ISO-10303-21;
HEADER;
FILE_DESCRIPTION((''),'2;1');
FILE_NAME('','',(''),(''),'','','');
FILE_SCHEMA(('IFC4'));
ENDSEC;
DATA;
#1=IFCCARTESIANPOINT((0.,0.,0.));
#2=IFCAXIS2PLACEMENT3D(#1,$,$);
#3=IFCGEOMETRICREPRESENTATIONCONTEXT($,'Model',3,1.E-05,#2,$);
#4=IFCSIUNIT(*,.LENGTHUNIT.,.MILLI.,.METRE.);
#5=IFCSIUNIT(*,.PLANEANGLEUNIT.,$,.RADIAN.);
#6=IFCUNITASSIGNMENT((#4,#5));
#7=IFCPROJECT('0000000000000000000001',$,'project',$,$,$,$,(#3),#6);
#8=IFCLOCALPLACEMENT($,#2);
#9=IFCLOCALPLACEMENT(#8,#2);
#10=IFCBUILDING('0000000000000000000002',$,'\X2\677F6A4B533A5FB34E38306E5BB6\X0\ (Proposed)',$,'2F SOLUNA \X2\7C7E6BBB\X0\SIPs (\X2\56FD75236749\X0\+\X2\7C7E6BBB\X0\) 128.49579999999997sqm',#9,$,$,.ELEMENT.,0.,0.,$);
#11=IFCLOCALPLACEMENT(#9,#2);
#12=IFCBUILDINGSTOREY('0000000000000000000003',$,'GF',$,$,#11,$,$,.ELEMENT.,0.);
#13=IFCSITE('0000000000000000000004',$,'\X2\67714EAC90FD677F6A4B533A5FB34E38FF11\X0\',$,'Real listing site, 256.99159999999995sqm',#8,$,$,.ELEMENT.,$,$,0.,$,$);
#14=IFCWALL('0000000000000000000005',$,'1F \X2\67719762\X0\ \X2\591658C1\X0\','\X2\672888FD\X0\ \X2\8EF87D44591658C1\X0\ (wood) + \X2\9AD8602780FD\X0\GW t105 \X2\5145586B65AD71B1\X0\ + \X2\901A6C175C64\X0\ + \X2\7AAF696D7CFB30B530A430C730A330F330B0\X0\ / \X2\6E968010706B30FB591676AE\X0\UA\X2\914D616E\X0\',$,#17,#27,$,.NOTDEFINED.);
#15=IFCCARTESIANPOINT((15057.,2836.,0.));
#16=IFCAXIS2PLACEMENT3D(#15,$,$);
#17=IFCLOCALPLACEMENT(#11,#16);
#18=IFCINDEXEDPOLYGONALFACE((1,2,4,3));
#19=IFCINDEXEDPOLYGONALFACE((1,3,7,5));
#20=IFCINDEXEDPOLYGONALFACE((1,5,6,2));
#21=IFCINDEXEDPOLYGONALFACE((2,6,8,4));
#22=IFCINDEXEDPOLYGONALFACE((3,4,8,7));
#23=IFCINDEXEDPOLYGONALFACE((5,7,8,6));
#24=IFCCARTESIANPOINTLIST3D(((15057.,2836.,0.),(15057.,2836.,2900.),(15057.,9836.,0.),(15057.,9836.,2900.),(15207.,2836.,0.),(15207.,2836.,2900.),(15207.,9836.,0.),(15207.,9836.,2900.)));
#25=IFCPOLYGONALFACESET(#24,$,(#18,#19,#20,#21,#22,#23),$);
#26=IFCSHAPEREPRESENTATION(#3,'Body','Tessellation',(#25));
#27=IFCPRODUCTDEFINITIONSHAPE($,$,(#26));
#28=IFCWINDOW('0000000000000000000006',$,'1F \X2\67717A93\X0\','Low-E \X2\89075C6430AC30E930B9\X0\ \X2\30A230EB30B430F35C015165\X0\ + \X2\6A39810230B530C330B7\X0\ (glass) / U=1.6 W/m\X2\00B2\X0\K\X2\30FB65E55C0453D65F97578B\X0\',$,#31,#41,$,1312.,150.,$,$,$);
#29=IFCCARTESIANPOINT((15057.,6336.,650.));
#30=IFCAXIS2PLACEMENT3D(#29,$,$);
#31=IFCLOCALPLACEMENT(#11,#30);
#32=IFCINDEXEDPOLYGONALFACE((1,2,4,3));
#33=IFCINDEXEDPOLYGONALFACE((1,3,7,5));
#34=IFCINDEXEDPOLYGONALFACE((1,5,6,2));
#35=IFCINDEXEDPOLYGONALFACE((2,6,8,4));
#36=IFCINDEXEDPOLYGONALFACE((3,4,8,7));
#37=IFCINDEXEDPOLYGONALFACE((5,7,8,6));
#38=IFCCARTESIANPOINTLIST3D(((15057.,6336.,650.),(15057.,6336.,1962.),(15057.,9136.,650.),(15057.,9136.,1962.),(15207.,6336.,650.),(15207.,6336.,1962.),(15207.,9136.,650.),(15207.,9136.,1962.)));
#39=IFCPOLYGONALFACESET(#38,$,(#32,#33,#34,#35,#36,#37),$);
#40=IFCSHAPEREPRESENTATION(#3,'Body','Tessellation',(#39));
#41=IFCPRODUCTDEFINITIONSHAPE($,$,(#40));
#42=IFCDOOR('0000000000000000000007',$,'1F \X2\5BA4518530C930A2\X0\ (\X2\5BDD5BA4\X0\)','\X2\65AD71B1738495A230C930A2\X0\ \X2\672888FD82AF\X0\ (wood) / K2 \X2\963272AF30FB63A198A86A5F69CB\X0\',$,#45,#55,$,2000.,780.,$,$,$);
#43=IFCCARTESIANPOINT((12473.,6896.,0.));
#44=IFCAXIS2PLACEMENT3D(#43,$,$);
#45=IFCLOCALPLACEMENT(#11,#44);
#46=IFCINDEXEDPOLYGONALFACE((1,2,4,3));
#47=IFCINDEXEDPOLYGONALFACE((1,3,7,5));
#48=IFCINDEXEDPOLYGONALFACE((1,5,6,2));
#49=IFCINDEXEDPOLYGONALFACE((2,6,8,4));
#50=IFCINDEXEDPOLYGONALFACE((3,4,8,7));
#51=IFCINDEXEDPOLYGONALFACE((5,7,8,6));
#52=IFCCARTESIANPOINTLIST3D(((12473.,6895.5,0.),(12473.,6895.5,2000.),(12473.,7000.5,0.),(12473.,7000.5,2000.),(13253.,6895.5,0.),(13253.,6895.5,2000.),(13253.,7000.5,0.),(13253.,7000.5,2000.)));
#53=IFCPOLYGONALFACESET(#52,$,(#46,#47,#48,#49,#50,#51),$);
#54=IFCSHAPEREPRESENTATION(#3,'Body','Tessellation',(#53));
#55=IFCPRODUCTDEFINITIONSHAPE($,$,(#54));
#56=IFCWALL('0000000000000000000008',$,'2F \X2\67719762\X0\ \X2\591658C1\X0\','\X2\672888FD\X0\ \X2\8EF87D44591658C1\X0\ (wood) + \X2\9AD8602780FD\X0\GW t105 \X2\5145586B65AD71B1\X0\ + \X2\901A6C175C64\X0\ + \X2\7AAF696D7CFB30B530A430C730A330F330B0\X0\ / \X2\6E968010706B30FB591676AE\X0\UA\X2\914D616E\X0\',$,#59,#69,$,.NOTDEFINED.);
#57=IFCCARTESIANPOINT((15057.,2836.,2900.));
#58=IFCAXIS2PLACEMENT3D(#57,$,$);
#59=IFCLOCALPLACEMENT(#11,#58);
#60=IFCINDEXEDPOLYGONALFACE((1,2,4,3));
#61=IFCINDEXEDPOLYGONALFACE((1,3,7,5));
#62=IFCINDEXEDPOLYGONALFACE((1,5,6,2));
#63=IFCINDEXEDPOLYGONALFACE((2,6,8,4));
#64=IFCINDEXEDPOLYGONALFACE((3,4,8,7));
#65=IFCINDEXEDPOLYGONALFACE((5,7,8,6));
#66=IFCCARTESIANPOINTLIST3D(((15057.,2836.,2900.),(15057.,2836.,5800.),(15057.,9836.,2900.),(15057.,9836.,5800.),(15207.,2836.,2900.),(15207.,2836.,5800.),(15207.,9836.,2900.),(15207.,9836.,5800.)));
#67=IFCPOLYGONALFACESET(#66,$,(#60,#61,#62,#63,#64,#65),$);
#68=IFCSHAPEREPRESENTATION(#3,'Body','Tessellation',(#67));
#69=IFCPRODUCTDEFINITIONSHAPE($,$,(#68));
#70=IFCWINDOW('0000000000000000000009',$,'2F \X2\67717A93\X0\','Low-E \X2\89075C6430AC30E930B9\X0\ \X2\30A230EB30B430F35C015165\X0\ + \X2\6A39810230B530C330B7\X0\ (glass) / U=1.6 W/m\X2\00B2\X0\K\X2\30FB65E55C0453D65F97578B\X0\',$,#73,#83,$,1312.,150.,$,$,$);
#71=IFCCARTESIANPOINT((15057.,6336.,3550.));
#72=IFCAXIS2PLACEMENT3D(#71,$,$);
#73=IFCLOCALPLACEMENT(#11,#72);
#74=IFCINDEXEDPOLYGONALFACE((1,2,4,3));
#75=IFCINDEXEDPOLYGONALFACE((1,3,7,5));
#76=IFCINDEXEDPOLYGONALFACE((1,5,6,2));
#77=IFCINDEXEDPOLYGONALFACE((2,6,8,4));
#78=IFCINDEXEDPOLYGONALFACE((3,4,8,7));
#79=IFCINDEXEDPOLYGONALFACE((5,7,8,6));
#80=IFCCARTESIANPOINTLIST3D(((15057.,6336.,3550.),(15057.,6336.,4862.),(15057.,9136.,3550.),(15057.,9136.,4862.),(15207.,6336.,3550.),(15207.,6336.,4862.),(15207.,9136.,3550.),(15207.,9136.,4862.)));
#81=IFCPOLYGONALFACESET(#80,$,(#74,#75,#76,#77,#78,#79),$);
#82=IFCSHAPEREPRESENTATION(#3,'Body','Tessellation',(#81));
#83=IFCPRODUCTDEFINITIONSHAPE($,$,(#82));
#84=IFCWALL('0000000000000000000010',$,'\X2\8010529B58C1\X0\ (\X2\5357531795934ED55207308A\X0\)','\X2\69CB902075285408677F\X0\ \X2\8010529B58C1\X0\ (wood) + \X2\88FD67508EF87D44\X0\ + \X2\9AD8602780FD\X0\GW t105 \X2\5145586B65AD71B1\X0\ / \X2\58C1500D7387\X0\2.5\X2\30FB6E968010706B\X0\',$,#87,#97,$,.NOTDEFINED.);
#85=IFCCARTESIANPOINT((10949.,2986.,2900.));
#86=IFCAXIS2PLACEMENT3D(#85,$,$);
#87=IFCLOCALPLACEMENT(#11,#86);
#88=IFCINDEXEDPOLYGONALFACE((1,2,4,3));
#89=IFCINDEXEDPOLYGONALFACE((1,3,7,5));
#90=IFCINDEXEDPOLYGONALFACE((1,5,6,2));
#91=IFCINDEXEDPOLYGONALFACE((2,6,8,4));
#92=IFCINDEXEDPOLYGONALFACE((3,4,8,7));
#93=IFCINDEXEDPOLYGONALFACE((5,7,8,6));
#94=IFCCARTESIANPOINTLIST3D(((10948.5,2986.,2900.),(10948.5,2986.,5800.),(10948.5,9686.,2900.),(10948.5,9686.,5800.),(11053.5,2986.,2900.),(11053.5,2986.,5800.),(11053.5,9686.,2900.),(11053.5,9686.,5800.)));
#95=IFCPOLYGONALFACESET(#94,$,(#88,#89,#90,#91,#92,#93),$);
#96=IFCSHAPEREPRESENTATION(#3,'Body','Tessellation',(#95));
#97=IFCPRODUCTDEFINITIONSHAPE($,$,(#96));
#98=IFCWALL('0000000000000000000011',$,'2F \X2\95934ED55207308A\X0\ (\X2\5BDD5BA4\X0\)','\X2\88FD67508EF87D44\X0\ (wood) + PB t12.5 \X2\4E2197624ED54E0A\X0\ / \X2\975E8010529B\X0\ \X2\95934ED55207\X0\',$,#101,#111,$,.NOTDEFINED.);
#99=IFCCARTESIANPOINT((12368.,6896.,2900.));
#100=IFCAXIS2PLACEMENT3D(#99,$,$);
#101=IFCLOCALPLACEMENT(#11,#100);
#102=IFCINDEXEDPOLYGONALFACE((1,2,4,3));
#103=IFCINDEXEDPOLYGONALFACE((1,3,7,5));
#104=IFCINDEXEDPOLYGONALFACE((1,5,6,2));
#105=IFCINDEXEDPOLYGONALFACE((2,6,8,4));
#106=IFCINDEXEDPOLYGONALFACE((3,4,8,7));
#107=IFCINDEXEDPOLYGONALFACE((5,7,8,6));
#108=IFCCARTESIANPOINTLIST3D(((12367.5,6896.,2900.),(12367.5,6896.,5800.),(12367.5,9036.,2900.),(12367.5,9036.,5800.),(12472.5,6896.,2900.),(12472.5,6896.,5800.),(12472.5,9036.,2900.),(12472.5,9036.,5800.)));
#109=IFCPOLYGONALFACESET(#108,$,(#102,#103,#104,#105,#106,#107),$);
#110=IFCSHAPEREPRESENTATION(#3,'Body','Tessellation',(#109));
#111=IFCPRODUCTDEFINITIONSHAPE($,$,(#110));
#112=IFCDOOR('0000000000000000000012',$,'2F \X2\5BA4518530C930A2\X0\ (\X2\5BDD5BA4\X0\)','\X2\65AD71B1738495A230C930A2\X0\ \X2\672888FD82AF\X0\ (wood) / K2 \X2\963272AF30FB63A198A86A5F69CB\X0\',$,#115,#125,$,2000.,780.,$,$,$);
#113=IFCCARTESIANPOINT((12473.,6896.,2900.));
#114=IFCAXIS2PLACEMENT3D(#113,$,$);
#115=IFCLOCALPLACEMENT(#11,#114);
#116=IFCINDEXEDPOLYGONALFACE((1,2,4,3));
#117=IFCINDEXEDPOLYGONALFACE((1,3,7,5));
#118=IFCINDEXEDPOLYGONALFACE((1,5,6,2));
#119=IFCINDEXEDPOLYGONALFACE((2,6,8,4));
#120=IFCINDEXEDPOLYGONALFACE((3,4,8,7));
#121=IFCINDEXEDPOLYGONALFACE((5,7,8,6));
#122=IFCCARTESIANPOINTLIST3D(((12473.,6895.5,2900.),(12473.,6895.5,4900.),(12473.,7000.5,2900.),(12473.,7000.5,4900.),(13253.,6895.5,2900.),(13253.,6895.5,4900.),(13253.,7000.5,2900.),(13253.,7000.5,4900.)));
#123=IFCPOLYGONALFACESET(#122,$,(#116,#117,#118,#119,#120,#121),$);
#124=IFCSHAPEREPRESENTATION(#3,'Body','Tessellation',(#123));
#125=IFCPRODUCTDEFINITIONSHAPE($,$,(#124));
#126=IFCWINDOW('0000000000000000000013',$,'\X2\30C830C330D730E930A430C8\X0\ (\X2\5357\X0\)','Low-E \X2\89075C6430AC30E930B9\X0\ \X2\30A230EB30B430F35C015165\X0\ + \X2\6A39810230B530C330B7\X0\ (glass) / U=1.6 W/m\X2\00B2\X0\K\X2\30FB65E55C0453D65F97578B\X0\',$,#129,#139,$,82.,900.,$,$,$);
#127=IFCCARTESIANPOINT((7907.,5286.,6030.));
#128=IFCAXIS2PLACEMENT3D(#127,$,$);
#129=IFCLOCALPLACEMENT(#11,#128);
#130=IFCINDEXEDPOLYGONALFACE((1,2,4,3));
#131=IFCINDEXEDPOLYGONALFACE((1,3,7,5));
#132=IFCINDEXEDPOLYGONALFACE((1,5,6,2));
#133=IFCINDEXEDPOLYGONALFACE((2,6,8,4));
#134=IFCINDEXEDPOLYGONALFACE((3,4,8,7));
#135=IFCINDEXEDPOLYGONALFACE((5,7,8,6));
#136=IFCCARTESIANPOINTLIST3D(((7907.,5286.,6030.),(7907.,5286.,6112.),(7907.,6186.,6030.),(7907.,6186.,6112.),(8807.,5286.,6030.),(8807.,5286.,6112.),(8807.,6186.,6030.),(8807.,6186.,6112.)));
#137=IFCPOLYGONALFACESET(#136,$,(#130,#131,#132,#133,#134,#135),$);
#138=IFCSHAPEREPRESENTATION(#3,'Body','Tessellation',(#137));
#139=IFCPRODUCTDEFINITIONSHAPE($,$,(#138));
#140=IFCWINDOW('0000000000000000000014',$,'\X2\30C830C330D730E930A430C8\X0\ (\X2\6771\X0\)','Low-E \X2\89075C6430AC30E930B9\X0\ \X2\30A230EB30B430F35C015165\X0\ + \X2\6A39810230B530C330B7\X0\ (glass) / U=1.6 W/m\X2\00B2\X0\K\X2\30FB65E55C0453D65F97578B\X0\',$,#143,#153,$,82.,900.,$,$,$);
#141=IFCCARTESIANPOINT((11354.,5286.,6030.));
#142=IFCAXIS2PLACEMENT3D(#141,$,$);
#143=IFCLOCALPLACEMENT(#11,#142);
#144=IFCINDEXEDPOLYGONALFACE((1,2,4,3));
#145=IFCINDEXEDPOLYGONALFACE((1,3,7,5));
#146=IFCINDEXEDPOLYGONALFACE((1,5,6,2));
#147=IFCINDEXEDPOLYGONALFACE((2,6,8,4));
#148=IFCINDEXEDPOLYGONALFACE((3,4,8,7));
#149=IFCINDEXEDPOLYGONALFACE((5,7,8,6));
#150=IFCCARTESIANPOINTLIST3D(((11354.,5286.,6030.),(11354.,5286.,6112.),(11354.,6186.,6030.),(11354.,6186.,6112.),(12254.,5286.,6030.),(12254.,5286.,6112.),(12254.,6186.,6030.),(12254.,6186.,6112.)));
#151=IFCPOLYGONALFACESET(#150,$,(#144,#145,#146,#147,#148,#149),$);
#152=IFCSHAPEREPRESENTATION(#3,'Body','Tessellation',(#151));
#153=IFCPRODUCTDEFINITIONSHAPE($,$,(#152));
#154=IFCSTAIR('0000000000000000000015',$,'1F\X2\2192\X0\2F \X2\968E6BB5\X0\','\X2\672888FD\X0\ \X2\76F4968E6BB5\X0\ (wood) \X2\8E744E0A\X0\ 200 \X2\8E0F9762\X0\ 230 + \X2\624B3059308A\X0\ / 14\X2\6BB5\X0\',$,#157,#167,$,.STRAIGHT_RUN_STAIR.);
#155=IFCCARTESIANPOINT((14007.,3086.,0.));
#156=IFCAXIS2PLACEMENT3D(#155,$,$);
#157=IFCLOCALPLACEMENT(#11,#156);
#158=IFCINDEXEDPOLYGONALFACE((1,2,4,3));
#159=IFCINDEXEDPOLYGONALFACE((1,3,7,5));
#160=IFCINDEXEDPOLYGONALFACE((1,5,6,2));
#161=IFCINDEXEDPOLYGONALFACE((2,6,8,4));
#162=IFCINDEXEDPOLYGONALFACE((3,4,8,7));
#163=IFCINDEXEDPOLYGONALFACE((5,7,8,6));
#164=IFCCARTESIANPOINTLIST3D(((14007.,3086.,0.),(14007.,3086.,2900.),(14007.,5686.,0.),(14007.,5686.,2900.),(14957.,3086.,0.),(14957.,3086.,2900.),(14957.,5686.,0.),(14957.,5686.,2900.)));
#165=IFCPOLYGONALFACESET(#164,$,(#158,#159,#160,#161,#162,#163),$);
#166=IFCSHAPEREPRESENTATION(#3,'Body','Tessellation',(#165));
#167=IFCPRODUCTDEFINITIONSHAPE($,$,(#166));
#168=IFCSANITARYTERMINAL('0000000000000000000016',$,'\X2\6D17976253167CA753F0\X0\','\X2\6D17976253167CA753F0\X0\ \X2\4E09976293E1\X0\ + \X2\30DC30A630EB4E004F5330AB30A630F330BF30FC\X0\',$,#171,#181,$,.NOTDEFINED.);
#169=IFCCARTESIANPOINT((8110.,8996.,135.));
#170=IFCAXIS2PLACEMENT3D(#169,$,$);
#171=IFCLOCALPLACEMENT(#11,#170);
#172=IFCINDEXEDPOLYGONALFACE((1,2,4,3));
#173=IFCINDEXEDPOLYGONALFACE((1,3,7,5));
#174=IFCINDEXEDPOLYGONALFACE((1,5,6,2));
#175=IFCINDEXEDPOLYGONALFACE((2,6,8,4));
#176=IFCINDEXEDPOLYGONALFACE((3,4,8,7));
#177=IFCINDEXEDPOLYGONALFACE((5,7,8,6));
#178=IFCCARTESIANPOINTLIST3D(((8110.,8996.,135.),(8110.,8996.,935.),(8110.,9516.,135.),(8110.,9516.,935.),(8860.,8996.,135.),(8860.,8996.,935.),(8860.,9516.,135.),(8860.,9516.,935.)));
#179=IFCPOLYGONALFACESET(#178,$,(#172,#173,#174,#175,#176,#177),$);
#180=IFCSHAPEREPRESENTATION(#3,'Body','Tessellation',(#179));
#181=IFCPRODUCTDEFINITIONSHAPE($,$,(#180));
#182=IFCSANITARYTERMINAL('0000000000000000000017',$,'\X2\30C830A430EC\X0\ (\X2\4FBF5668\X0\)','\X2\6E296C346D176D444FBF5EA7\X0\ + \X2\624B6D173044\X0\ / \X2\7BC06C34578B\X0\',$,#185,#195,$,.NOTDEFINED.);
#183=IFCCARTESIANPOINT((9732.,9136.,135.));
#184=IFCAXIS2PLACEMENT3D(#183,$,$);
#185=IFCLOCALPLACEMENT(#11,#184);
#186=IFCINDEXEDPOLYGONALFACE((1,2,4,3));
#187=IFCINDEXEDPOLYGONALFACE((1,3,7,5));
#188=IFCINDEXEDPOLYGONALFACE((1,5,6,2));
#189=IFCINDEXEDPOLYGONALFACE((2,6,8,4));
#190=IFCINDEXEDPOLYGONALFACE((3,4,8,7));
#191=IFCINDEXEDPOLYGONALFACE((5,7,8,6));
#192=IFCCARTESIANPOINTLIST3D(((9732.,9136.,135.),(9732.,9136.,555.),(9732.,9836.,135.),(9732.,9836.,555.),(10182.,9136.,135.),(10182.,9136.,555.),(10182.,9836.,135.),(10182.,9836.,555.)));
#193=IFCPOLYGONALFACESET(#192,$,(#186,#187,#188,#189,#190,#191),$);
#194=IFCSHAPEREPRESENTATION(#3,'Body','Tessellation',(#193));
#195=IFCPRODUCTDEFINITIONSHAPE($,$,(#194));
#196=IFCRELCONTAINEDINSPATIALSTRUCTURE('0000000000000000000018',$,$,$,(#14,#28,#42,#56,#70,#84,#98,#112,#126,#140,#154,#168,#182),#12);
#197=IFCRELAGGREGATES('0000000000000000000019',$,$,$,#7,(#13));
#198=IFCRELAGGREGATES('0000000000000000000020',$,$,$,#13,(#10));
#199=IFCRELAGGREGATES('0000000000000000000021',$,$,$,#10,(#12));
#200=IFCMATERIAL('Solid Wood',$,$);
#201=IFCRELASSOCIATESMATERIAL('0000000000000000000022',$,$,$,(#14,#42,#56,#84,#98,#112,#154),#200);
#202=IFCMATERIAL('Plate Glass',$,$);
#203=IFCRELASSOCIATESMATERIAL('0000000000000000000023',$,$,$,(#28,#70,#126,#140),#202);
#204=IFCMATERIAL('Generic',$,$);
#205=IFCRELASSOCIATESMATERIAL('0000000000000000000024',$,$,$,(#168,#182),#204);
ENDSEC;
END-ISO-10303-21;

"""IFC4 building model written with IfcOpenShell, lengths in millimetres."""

from ifc_helpers import new_model, si_unit, frame, frame_2d, origin, place, context, project, spatial, rectangle, extrude, material, element, fill, save


model = new_model("IFC4")

# Units and contexts
model_context = context("Model", 3, precision=1e-05, world=origin())
ifc_project = project(units=[si_unit("LENGTHUNIT", "METRE", prefix="MILLI"), si_unit("PLANEANGLEUNIT", "RADIAN")], contexts=[model_context])

# Site, building, storey
site_placement = place(None, origin())
site = spatial("IfcSite", under=ifc_project, at=site_placement, Name="東京都板橋区徳丸１", ObjectType="Real listing site, 256.99159999999995sqm", CompositionType="ELEMENT", RefElevation=0.0)
building_placement = place(site_placement, origin())
building = spatial("IfcBuilding", under=site, at=building_placement, Name="板橋区徳丸の家 (Proposed)", ObjectType="2F SOLUNA 籾殻SIPs (国産杉+籾殻) 128.49579999999997sqm", CompositionType="ELEMENT", ElevationOfRefHeight=0.0, ElevationOfTerrain=0.0)
storey_placement = place(building_placement, origin())
storey = spatial("IfcBuildingStorey", under=building, at=storey_placement, Name="GF", CompositionType="ELEMENT", Elevation=0.0)

# Wall, opening, window
ifc_material_1 = material(Name="Solid Wood")
wall_1_placement = place(storey_placement, frame((15057.0, 2836.0, 0.0)))
wall_1 = element("IfcWall", 1, at=wall_1_placement, inside=storey, material=ifc_material_1, Name="1F 東面 外壁", Description="木製 軸組外壁 (wood) + 高性能GW t105 充填断熱 + 通気層 + 窯業系サイディング / 準耐火・外皮UA配慮", PredefinedType="NOTDEFINED", context=model_context, shape_type="SweptSolid", body=[
    extrude(rectangle(XDim=150.0, YDim=7000.0, at=frame_2d((75.0, 3500.0))), frame((15057.0, 2836.0, 0.0)), (0.0, 0.0, 1.0), 2900.0),
])
opening_1_placement = place(storey_placement, frame((15057.0, 6336.0, 650.0)))
opening_1 = element("IfcOpeningElement", 2, at=opening_1_placement, cuts=wall_1, PredefinedType="NOTDEFINED", context=model_context, shape_type="SweptSolid", body=[
    extrude(rectangle(XDim=150.0, YDim=2800.0, at=frame_2d((75.0, 1400.0))), frame((15057.0, 6336.0, 650.0)), (0.0, 0.0, 1.0), 1312.0),
])
ifc_material_2 = material(Name="Plate Glass")
window_1_placement = place(storey_placement, frame((15057.0, 6336.0, 650.0)))
window_1 = element("IfcWindow", 3, at=window_1_placement, inside=storey, material=ifc_material_2, Name="1F 東窓", Description="Low-E 複層ガラス アルゴン封入 + 樹脂サッシ (glass) / U=1.6 W/m²K・日射取得型", OverallHeight=1312.0, OverallWidth=150.0, context=model_context, shape_type="SweptSolid", body=[
    extrude(rectangle(XDim=150.0, YDim=2800.0, at=frame_2d((75.0, 1400.0))), frame((15057.0, 6336.0, 650.0)), (0.0, 0.0, 1.0), 1312.0),
])
fill(opening_1, window_1)

# Door
door_1_placement = place(storey_placement, frame((12473.0, 6896.0, 0.0)))
element("IfcDoor", 4, at=door_1_placement, inside=storey, material=ifc_material_1, Name="1F 室内ドア (寝室)", Description="断熱玄関ドア 木製芯 (wood) / K2 防犯・採風機構", OverallHeight=2000.0, OverallWidth=780.0, context=model_context, shape_type="SweptSolid", body=[
    extrude(rectangle(XDim=780.0, YDim=105.0, at=frame_2d((390.0, 52.0))), frame((12473.0, 6896.0, 0.0)), (0.0, 0.0, 1.0), 2000.0),
])

# Wall, opening, window
wall_2_placement = place(storey_placement, frame((15057.0, 2836.0, 2900.0)))
wall_2 = element("IfcWall", 5, at=wall_2_placement, inside=storey, material=ifc_material_1, Name="2F 東面 外壁", Description="木製 軸組外壁 (wood) + 高性能GW t105 充填断熱 + 通気層 + 窯業系サイディング / 準耐火・外皮UA配慮", PredefinedType="NOTDEFINED", context=model_context, shape_type="SweptSolid", body=[
    extrude(rectangle(XDim=150.0, YDim=7000.0, at=frame_2d((75.0, 3500.0))), frame((15057.0, 2836.0, 2900.0)), (0.0, 0.0, 1.0), 2900.0),
])
opening_2_placement = place(storey_placement, frame((15057.0, 6336.0, 3550.0)))
opening_2 = element("IfcOpeningElement", 6, at=opening_2_placement, cuts=wall_2, PredefinedType="NOTDEFINED", context=model_context, shape_type="SweptSolid", body=[
    extrude(rectangle(XDim=150.0, YDim=2800.0, at=frame_2d((75.0, 1400.0))), frame((15057.0, 6336.0, 3550.0)), (0.0, 0.0, 1.0), 1312.0),
])
window_2_placement = place(storey_placement, frame((15057.0, 6336.0, 3550.0)))
window_2 = element("IfcWindow", 7, at=window_2_placement, inside=storey, material=ifc_material_2, Name="2F 東窓", Description="Low-E 複層ガラス アルゴン封入 + 樹脂サッシ (glass) / U=1.6 W/m²K・日射取得型", OverallHeight=1312.0, OverallWidth=150.0, context=model_context, shape_type="SweptSolid", body=[
    extrude(rectangle(XDim=150.0, YDim=2800.0, at=frame_2d((75.0, 1400.0))), frame((15057.0, 6336.0, 3550.0)), (0.0, 0.0, 1.0), 1312.0),
])
fill(opening_2, window_2)

# Walls
wall_3_placement = place(storey_placement, frame((10949.0, 2986.0, 2900.0)))
element("IfcWall", 8, at=wall_3_placement, inside=storey, material=ifc_material_1, Name="耐力壁 (南北間仕切り)", Description="構造用合板 耐力壁 (wood) + 製材軸組 + 高性能GW t105 充填断熱 / 壁倍率2.5・準耐火", PredefinedType="NOTDEFINED", context=model_context, shape_type="SweptSolid", body=[
    extrude(rectangle(XDim=105.0, YDim=6700.0, at=frame_2d((52.0, 3350.0))), frame((10949.0, 2986.0, 2900.0)), (0.0, 0.0, 1.0), 2900.0),
])
wall_4_placement = place(storey_placement, frame((12368.0, 6896.0, 2900.0)))
element("IfcWall", 9, at=wall_4_placement, inside=storey, material=ifc_material_1, Name="2F 間仕切り (寝室)", Description="製材軸組 (wood) + PB t12.5 両面仕上 / 非耐力 間仕切", PredefinedType="NOTDEFINED", context=model_context, shape_type="SweptSolid", body=[
    extrude(rectangle(XDim=105.0, YDim=2140.0, at=frame_2d((52.0, 1070.0))), frame((12368.0, 6896.0, 2900.0)), (0.0, 0.0, 1.0), 2900.0),
])

# Door
door_2_placement = place(storey_placement, frame((12473.0, 6896.0, 2900.0)))
element("IfcDoor", 10, at=door_2_placement, inside=storey, material=ifc_material_1, Name="2F 室内ドア (寝室)", Description="断熱玄関ドア 木製芯 (wood) / K2 防犯・採風機構", OverallHeight=2000.0, OverallWidth=780.0, context=model_context, shape_type="SweptSolid", body=[
    extrude(rectangle(XDim=780.0, YDim=105.0, at=frame_2d((390.0, 52.0))), frame((12473.0, 6896.0, 2900.0)), (0.0, 0.0, 1.0), 2000.0),
])

# Windows
window_3_placement = place(storey_placement, frame((7907.0, 5286.0, 6030.0)))
element("IfcWindow", 11, at=window_3_placement, inside=storey, material=ifc_material_2, Name="トップライト (南)", Description="Low-E 複層ガラス アルゴン封入 + 樹脂サッシ (glass) / U=1.6 W/m²K・日射取得型", OverallHeight=82.0, OverallWidth=900.0, context=model_context, shape_type="SweptSolid", body=[
    extrude(rectangle(XDim=900.0, YDim=900.0, at=frame_2d((450.0, 450.0))), frame((7907.0, 5286.0, 6030.0)), (0.0, 0.0, 1.0), 82.0),
])
window_4_placement = place(storey_placement, frame((11354.0, 5286.0, 6030.0)))
element("IfcWindow", 12, at=window_4_placement, inside=storey, material=ifc_material_2, Name="トップライト (東)", Description="Low-E 複層ガラス アルゴン封入 + 樹脂サッシ (glass) / U=1.6 W/m²K・日射取得型", OverallHeight=82.0, OverallWidth=900.0, context=model_context, shape_type="SweptSolid", body=[
    extrude(rectangle(XDim=900.0, YDim=900.0, at=frame_2d((450.0, 450.0))), frame((11354.0, 5286.0, 6030.0)), (0.0, 0.0, 1.0), 82.0),
])

# Stair
stair_placement = place(storey_placement, frame((14007.0, 3086.0, 0.0)))
element("IfcStair", 13, at=stair_placement, inside=storey, material=ifc_material_1, Name="1F→2F 階段", Description="木製 直階段 (wood) 蹴上 200 踏面 230 + 手すり / 14段", PredefinedType="STRAIGHT_RUN_STAIR", context=model_context, shape_type="SweptSolid", body=[
    extrude(rectangle(XDim=950.0, YDim=2600.0, at=frame_2d((475.0, 1300.0))), frame((14007.0, 3086.0, 0.0)), (0.0, 0.0, 1.0), 2900.0),
])

# Sanitary terminals
ifc_material_3 = material(Name="Generic")
sanitary_terminal_1_placement = place(storey_placement, frame((8110.0, 8996.0, 135.0)))
element("IfcSanitaryTerminal", 14, at=sanitary_terminal_1_placement, inside=storey, material=ifc_material_3, Name="洗面化粧台", Description="洗面化粧台 三面鏡 + ボウル一体カウンター", PredefinedType="NOTDEFINED", context=model_context, shape_type="SweptSolid", body=[
    extrude(rectangle(XDim=750.0, YDim=520.0, at=frame_2d((375.0, 260.0))), frame((8110.0, 8996.0, 135.0)), (0.0, 0.0, 1.0), 800.0),
])
sanitary_terminal_2_placement = place(storey_placement, frame((9732.0, 9136.0, 135.0)))
element("IfcSanitaryTerminal", 15, at=sanitary_terminal_2_placement, inside=storey, material=ifc_material_3, Name="トイレ (便器)", Description="温水洗浄便座 + 手洗い / 節水型", PredefinedType="NOTDEFINED", context=model_context, shape_type="SweptSolid", body=[
    extrude(rectangle(XDim=450.0, YDim=700.0, at=frame_2d((225.0, 350.0))), frame((9732.0, 9136.0, 135.0)), (0.0, 0.0, 1.0), 420.0),
])

save(model, "model.ifc")
